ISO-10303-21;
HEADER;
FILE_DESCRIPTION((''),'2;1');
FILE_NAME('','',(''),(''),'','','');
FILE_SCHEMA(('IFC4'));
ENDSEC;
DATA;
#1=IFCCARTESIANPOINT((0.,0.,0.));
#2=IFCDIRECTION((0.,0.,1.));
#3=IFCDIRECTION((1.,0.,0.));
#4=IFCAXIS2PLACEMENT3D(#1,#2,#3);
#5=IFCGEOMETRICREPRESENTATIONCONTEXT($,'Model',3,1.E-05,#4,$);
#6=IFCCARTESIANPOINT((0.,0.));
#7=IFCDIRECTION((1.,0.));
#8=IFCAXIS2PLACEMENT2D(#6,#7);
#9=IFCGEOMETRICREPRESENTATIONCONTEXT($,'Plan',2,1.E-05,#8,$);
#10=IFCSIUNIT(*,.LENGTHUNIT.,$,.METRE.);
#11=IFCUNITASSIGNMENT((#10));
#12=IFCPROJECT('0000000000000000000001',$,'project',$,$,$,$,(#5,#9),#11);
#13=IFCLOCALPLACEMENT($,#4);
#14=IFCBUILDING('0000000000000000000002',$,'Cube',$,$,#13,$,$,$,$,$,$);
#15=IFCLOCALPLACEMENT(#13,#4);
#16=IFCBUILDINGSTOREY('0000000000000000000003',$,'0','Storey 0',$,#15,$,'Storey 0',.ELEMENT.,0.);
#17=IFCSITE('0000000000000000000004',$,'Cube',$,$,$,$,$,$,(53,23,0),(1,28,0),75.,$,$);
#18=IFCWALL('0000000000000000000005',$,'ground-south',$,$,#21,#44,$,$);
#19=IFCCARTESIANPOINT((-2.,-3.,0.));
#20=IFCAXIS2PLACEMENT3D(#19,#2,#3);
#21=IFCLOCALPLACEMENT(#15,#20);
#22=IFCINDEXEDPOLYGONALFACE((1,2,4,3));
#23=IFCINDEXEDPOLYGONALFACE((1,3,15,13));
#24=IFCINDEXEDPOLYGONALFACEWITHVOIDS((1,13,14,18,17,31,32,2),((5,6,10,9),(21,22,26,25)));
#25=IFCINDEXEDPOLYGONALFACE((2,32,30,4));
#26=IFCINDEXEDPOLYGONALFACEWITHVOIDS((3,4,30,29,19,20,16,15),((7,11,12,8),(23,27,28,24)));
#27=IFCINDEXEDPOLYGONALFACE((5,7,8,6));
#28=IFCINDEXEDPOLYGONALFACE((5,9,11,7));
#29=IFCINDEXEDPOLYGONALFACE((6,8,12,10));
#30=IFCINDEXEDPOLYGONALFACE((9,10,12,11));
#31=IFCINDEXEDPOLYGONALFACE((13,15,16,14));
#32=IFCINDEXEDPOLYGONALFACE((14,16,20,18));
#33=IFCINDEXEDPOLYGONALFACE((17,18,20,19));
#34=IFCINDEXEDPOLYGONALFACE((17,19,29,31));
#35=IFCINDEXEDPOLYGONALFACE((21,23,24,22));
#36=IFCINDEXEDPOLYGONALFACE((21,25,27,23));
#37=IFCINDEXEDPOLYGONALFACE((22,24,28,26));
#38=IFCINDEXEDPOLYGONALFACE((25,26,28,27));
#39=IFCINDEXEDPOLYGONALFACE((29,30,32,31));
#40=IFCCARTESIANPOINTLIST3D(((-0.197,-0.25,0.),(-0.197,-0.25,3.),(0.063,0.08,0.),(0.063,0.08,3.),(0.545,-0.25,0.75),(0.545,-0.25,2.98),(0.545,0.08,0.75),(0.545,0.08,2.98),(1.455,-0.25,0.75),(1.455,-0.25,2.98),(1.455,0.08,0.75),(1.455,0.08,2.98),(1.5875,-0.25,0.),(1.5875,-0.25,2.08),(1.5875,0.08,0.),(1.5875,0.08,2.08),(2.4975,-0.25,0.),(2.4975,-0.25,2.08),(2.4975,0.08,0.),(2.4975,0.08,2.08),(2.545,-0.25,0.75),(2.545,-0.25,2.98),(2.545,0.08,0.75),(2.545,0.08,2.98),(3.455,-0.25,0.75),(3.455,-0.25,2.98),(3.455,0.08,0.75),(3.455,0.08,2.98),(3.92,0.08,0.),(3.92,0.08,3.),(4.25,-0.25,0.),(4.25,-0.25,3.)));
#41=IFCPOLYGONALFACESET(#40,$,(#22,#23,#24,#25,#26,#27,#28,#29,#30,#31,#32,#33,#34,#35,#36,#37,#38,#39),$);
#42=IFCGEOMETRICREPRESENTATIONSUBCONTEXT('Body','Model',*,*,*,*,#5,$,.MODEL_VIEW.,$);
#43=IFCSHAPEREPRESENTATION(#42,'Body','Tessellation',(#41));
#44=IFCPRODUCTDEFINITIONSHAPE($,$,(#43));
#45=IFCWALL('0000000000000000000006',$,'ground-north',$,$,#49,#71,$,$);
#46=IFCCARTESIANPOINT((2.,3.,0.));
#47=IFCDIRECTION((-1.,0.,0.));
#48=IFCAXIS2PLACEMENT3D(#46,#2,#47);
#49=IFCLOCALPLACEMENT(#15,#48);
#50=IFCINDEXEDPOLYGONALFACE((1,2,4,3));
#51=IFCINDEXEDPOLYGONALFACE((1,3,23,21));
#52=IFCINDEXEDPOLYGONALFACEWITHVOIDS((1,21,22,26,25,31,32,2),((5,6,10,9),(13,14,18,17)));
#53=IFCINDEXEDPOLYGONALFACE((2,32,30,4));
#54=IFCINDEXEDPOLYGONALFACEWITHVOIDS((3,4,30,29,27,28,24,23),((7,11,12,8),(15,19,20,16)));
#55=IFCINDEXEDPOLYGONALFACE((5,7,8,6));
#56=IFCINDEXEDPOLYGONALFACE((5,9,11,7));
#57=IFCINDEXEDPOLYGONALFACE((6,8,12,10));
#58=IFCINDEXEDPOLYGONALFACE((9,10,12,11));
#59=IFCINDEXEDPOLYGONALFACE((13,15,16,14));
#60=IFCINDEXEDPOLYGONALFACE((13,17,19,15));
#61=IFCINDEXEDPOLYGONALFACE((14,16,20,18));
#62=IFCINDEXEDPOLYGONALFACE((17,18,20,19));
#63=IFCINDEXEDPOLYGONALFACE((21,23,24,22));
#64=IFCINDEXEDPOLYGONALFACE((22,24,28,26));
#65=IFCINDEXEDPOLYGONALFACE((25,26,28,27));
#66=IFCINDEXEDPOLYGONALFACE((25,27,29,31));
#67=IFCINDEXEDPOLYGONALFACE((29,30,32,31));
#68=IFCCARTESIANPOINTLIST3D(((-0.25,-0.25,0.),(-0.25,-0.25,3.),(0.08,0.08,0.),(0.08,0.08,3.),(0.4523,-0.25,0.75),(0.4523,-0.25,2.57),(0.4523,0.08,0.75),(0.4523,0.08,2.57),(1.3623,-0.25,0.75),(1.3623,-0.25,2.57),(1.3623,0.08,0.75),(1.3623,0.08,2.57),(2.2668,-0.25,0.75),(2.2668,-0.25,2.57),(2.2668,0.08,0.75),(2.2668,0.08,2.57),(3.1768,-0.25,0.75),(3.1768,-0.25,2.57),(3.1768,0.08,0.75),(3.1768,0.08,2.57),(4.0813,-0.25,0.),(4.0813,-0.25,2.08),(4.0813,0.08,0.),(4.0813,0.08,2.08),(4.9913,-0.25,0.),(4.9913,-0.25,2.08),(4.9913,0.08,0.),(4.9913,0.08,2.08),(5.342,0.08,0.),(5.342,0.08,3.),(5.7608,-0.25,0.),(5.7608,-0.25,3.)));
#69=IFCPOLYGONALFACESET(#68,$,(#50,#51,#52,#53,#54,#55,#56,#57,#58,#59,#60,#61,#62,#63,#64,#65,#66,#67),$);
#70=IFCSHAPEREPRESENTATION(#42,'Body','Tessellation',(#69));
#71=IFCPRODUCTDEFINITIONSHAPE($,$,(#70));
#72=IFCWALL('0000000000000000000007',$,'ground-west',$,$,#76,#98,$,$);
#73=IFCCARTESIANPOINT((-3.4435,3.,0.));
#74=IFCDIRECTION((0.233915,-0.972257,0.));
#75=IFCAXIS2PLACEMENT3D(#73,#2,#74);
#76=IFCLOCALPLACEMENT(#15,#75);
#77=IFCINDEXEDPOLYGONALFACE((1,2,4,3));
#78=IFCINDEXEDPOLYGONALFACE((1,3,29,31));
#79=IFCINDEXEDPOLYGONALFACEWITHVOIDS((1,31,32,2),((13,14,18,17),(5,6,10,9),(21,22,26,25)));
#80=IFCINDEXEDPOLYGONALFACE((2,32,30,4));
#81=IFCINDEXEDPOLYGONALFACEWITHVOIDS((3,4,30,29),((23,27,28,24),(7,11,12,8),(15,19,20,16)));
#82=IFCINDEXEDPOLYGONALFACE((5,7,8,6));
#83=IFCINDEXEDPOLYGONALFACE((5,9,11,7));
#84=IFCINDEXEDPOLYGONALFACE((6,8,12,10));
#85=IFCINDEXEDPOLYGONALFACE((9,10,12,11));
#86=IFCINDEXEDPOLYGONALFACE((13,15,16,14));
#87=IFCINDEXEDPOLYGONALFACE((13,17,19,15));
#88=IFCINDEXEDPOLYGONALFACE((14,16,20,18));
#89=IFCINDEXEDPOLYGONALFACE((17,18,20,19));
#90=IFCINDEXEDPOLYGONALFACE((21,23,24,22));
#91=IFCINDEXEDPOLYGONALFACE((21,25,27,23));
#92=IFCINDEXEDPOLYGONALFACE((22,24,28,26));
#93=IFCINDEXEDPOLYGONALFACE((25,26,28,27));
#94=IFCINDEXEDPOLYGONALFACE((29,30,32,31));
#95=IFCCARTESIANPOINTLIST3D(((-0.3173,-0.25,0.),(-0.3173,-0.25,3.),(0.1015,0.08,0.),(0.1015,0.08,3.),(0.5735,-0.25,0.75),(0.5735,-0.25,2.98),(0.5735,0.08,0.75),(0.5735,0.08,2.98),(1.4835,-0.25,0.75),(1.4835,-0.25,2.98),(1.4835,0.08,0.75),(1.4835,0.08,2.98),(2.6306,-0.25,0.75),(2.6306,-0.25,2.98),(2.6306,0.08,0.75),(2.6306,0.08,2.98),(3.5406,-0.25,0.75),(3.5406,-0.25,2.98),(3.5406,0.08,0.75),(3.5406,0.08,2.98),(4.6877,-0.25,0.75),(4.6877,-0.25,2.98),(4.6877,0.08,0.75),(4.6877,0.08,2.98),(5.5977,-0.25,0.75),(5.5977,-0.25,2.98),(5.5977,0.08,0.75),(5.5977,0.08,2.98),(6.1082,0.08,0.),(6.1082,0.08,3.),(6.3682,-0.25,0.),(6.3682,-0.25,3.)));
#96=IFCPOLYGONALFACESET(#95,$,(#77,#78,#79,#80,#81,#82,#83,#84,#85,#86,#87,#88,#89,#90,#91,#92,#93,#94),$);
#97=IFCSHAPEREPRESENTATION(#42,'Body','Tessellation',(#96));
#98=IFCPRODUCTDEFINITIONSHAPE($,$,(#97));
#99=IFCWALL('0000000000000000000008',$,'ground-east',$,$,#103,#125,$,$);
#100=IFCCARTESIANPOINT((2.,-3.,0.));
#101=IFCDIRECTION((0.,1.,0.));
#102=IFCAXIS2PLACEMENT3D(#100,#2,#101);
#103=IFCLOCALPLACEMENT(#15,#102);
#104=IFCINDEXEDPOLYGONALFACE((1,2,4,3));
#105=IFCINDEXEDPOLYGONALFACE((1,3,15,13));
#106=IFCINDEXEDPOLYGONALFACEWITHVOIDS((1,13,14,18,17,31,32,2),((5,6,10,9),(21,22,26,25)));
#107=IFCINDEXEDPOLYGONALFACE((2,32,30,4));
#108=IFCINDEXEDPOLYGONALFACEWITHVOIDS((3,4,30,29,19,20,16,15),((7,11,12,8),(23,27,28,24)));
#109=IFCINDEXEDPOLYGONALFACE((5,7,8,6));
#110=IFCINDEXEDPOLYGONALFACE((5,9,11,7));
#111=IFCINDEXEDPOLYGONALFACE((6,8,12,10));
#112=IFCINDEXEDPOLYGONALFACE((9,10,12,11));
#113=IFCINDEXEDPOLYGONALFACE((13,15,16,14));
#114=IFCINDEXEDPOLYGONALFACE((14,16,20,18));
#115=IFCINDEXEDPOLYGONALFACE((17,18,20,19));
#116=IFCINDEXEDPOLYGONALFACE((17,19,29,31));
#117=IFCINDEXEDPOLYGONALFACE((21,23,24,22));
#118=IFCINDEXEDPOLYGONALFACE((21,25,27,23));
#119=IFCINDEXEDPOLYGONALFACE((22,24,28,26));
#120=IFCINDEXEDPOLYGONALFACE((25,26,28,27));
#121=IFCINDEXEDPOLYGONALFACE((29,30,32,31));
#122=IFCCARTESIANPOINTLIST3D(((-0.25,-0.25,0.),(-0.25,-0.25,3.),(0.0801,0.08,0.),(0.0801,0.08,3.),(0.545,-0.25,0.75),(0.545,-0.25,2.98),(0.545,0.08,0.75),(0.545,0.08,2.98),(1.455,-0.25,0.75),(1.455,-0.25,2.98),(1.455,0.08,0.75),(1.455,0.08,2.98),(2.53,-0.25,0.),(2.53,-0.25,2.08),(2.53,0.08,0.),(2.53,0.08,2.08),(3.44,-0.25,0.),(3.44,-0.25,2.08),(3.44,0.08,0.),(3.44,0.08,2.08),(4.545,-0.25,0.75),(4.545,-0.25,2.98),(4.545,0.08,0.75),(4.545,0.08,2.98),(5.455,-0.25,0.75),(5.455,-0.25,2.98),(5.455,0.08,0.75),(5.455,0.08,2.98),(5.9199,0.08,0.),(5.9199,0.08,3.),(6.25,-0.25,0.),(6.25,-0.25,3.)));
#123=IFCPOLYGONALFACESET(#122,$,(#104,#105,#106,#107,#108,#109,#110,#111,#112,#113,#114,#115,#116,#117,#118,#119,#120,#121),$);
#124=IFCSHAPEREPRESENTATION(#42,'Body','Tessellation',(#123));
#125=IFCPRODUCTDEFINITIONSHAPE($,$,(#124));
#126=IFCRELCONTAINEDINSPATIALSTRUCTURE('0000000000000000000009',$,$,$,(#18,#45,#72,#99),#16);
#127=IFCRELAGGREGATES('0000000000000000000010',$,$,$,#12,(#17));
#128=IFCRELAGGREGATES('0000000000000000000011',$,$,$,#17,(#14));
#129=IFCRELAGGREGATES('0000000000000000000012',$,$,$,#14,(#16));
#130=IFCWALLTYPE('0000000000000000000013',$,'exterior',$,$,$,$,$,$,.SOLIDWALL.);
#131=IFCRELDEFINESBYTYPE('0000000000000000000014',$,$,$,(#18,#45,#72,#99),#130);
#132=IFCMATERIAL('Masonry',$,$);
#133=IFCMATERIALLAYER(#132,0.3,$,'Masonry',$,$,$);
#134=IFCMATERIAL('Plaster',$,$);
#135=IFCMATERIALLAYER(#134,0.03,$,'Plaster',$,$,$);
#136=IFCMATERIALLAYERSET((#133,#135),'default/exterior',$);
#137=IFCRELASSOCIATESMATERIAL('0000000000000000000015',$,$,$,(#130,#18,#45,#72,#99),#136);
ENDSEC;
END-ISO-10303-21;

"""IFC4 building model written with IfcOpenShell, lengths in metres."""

from ifc_helpers import new_model, si_unit, frame, origin_with_axes, origin_2d_with_axis, place, context, subcontext, project, spatial, line, indexed_curve, outline, extrude, material, layer, layer_set, layer_usage, type_object, element, save


model = new_model("IFC4")

# Units and contexts
model_context = context("Model", 3, precision=1e-05, world=origin_with_axes())
plan_context = context("Plan", 2, precision=1e-05, world=origin_2d_with_axis())
body_context = subcontext(model_context, "Body", "Model", "MODEL_VIEW")
ifc_project = project(units=[si_unit("LENGTHUNIT", "METRE")], contexts=[model_context, plan_context])

# Site, building, storey
site = spatial("IfcSite", under=ifc_project, Name="Cube", RefLatitude=(53, 23, 0), RefLongitude=(1, 28, 0), RefElevation=75.0)
building_placement = place(None, origin_with_axes())
building = spatial("IfcBuilding", under=site, at=building_placement, Name="Cube")
storey_placement = place(building_placement, origin_with_axes())
storey = spatial("IfcBuildingStorey", under=building, at=storey_placement, Name="0", Description="Storey 0", LongName="Storey 0", CompositionType="ELEMENT", Elevation=0.0)

# Shared definitions
ifc_material_1 = material(Name="Masonry")
ifc_layer_1 = layer(ifc_material_1, 0.3, Name="Masonry")
ifc_material_2 = material(Name="Plaster")
ifc_layer_2 = layer(ifc_material_2, 0.03, Name="Plaster")
ifc_layer_set_1 = layer_set([ifc_layer_1, ifc_layer_2], Name="default/exterior")
wall_type = type_object("IfcWallType", Name="exterior", PredefinedType="SOLIDWALL", material=ifc_layer_set_1)

# Walls, openings
ifc_layer_usage_1 = layer_usage(ifc_layer_set_1, "AXIS2", "POSITIVE", 0.0)
wall_1_placement = place(storey_placement, frame((-2.0, -3.0, 0.0), z_axis=(0.0, 0.0, 1.0), x_axis=(1.0, 0.0, 0.0)))
wall_1 = element("IfcWall", 1, at=wall_1_placement, inside=storey, type_object=wall_type, material=ifc_layer_usage_1, Name="ground-south", context=body_context, shape_type="SweptSolid", body=[
    extrude(outline(indexed_curve([(0.063, 0.08), (-0.197, -0.25), (4.25, -0.25), (3.92, 0.08)], segments=[line(1, 2, 3, 4, 1)])), origin_with_axes(), (0.0, 0.0, 1.0), 3.0),
])
opening_1_placement = place(wall_1_placement, frame((0.545, -0.25, 0.75), z_axis=(0.0, 0.0, 1.0), x_axis=(1.0, 0.0, 0.0)))
element("IfcOpeningElement", 2, at=opening_1_placement, cuts=wall_1, PredefinedType="OPENING", context=body_context, shape_type="SweptSolid", body=[
    extrude(outline(indexed_curve([(0.0, 0.0), (0.0, 0.5), (0.91, 0.5), (0.91, 0.0), (0.0, 0.0)], self_intersect=False)), origin_with_axes(), (0.0, 0.0, 1.0), 2.23),
])
opening_2_placement = place(wall_1_placement, frame((2.545, -0.25, 0.75), z_axis=(0.0, 0.0, 1.0), x_axis=(1.0, 0.0, 0.0)))
element("IfcOpeningElement", 3, at=opening_2_placement, cuts=wall_1, PredefinedType="OPENING", context=body_context, shape_type="SweptSolid", body=[
    extrude(outline(indexed_curve([(0.0, 0.0), (0.0, 0.5), (0.91, 0.5), (0.91, 0.0), (0.0, 0.0)], self_intersect=False)), origin_with_axes(), (0.0, 0.0, 1.0), 2.23),
])
opening_3_placement = place(wall_1_placement, frame((1.5875, -0.25, 0.0), z_axis=(0.0, 0.0, 1.0), x_axis=(1.0, 0.0, 0.0)))
element("IfcOpeningElement", 4, at=opening_3_placement, cuts=wall_1, PredefinedType="OPENING", context=body_context, shape_type="SweptSolid", body=[
    extrude(outline(indexed_curve([(0.0, 0.0), (0.0, 0.5), (0.91, 0.5), (0.91, 0.0), (0.0, 0.0)], self_intersect=False)), origin_with_axes(), (0.0, 0.0, 1.0), 2.08),
])
ifc_layer_usage_2 = layer_usage(ifc_layer_set_1, "AXIS2", "POSITIVE", 0.0)
wall_2_placement = place(storey_placement, frame((2.0, 3.0, 0.0), z_axis=(0.0, 0.0, 1.0), x_axis=(-1.0, 0.0, 0.0)))
wall_2 = element("IfcWall", 5, at=wall_2_placement, inside=storey, type_object=wall_type, material=ifc_layer_usage_2, Name="ground-north", context=body_context, shape_type="SweptSolid", body=[
    extrude(outline(indexed_curve([(0.08, 0.08), (-0.25, -0.25), (5.7608, -0.25), (5.342, 0.08)], segments=[line(1, 2, 3, 4, 1)])), origin_with_axes(), (0.0, 0.0, 1.0), 3.0),
])
opening_4_placement = place(wall_2_placement, frame((2.2668, -0.25, 0.75), z_axis=(0.0, 0.0, 1.0), x_axis=(1.0, 0.0, 0.0)))
element("IfcOpeningElement", 6, at=opening_4_placement, cuts=wall_2, PredefinedType="OPENING", context=body_context, shape_type="SweptSolid", body=[
    extrude(outline(indexed_curve([(0.0, 0.0), (0.0, 0.5), (0.91, 0.5), (0.91, 0.0), (0.0, 0.0)], self_intersect=False)), origin_with_axes(), (0.0, 0.0, 1.0), 1.82),
])
opening_5_placement = place(wall_2_placement, frame((0.4523, -0.25, 0.75), z_axis=(0.0, 0.0, 1.0), x_axis=(1.0, 0.0, 0.0)))
element("IfcOpeningElement", 7, at=opening_5_placement, cuts=wall_2, PredefinedType="OPENING", context=body_context, shape_type="SweptSolid", body=[
    extrude(outline(indexed_curve([(0.0, 0.0), (0.0, 0.5), (0.91, 0.5), (0.91, 0.0), (0.0, 0.0)], self_intersect=False)), origin_with_axes(), (0.0, 0.0, 1.0), 1.82),
])
opening_6_placement = place(wall_2_placement, frame((4.0813, -0.25, 0.0), z_axis=(0.0, 0.0, 1.0), x_axis=(1.0, 0.0, 0.0)))
element("IfcOpeningElement", 8, at=opening_6_placement, cuts=wall_2, PredefinedType="OPENING", context=body_context, shape_type="SweptSolid", body=[
    extrude(outline(indexed_curve([(0.0, 0.0), (0.0, 0.5), (0.91, 0.5), (0.91, 0.0), (0.0, 0.0)], self_intersect=False)), origin_with_axes(), (0.0, 0.0, 1.0), 2.08),
])
ifc_layer_usage_3 = layer_usage(ifc_layer_set_1, "AXIS2", "POSITIVE", 0.0)
wall_3_placement = place(storey_placement, frame((-3.4435, 3.0, 0.0), z_axis=(0.0, 0.0, 1.0), x_axis=(0.233915, -0.972257, 0.0)))
wall_3 = element("IfcWall", 9, at=wall_3_placement, inside=storey, type_object=wall_type, material=ifc_layer_usage_3, Name="ground-west", context=body_context, shape_type="SweptSolid", body=[
    extrude(outline(indexed_curve([(0.1015, 0.08), (-0.3173, -0.25), (6.3682, -0.25), (6.1082, 0.08)], segments=[line(1, 2, 3, 4, 1)])), origin_with_axes(), (0.0, 0.0, 1.0), 3.0),
])
opening_7_placement = place(wall_3_placement, frame((0.5735, -0.25, 0.75), z_axis=(0.0, 0.0, 1.0), x_axis=(1.0, 0.0, 0.0)))
element("IfcOpeningElement", 10, at=opening_7_placement, cuts=wall_3, PredefinedType="OPENING", context=body_context, shape_type="SweptSolid", body=[
    extrude(outline(indexed_curve([(0.0, 0.0), (0.0, 0.5), (0.91, 0.5), (0.91, 0.0), (0.0, 0.0)], self_intersect=False)), origin_with_axes(), (0.0, 0.0, 1.0), 2.23),
])
opening_8_placement = place(wall_3_placement, frame((2.6306, -0.25, 0.75), z_axis=(0.0, 0.0, 1.0), x_axis=(1.0, 0.0, 0.0)))
element("IfcOpeningElement", 11, at=opening_8_placement, cuts=wall_3, PredefinedType="OPENING", context=body_context, shape_type="SweptSolid", body=[
    extrude(outline(indexed_curve([(0.0, 0.0), (0.0, 0.5), (0.91, 0.5), (0.91, 0.0), (0.0, 0.0)], self_intersect=False)), origin_with_axes(), (0.0, 0.0, 1.0), 2.23),
])
opening_9_placement = place(wall_3_placement, frame((4.6877, -0.25, 0.75), z_axis=(0.0, 0.0, 1.0), x_axis=(1.0, 0.0, 0.0)))
element("IfcOpeningElement", 12, at=opening_9_placement, cuts=wall_3, PredefinedType="OPENING", context=body_context, shape_type="SweptSolid", body=[
    extrude(outline(indexed_curve([(0.0, 0.0), (0.0, 0.5), (0.91, 0.5), (0.91, 0.0), (0.0, 0.0)], self_intersect=False)), origin_with_axes(), (0.0, 0.0, 1.0), 2.23),
])
ifc_layer_usage_4 = layer_usage(ifc_layer_set_1, "AXIS2", "POSITIVE", 0.0)
wall_4_placement = place(storey_placement, frame((2.0, -3.0, 0.0), z_axis=(0.0, 0.0, 1.0), x_axis=(0.0, 1.0, 0.0)))
wall_4 = element("IfcWall", 13, at=wall_4_placement, inside=storey, type_object=wall_type, material=ifc_layer_usage_4, Name="ground-east", context=body_context, shape_type="SweptSolid", body=[
    extrude(outline(indexed_curve([(0.0801, 0.08), (-0.25, -0.25), (6.25, -0.25), (5.9199, 0.08)], segments=[line(1, 2, 3, 4, 1)])), origin_with_axes(), (0.0, 0.0, 1.0), 3.0),
])
opening_10_placement = place(wall_4_placement, frame((2.53, -0.25, 0.0), z_axis=(0.0, 0.0, 1.0), x_axis=(1.0, 0.0, 0.0)))
element("IfcOpeningElement", 14, at=opening_10_placement, cuts=wall_4, PredefinedType="OPENING", context=body_context, shape_type="SweptSolid", body=[
    extrude(outline(indexed_curve([(0.0, 0.0), (0.0, 0.5), (0.91, 0.5), (0.91, 0.0), (0.0, 0.0)], self_intersect=False)), origin_with_axes(), (0.0, 0.0, 1.0), 2.08),
])
opening_11_placement = place(wall_4_placement, frame((0.545, -0.25, 0.75), z_axis=(0.0, 0.0, 1.0), x_axis=(1.0, 0.0, 0.0)))
element("IfcOpeningElement", 15, at=opening_11_placement, cuts=wall_4, PredefinedType="OPENING", context=body_context, shape_type="SweptSolid", body=[
    extrude(outline(indexed_curve([(0.0, 0.0), (0.0, 0.5), (0.91, 0.5), (0.91, 0.0), (0.0, 0.0)], self_intersect=False)), origin_with_axes(), (0.0, 0.0, 1.0), 2.23),
])
opening_12_placement = place(wall_4_placement, frame((4.545, -0.25, 0.75), z_axis=(0.0, 0.0, 1.0), x_axis=(1.0, 0.0, 0.0)))
element("IfcOpeningElement", 16, at=opening_12_placement, cuts=wall_4, PredefinedType="OPENING", context=body_context, shape_type="SweptSolid", body=[
    extrude(outline(indexed_curve([(0.0, 0.0), (0.0, 0.5), (0.91, 0.5), (0.91, 0.0), (0.0, 0.0)], self_intersect=False)), origin_with_axes(), (0.0, 0.0, 1.0), 2.23),
])

save(model, "model.ifc")
